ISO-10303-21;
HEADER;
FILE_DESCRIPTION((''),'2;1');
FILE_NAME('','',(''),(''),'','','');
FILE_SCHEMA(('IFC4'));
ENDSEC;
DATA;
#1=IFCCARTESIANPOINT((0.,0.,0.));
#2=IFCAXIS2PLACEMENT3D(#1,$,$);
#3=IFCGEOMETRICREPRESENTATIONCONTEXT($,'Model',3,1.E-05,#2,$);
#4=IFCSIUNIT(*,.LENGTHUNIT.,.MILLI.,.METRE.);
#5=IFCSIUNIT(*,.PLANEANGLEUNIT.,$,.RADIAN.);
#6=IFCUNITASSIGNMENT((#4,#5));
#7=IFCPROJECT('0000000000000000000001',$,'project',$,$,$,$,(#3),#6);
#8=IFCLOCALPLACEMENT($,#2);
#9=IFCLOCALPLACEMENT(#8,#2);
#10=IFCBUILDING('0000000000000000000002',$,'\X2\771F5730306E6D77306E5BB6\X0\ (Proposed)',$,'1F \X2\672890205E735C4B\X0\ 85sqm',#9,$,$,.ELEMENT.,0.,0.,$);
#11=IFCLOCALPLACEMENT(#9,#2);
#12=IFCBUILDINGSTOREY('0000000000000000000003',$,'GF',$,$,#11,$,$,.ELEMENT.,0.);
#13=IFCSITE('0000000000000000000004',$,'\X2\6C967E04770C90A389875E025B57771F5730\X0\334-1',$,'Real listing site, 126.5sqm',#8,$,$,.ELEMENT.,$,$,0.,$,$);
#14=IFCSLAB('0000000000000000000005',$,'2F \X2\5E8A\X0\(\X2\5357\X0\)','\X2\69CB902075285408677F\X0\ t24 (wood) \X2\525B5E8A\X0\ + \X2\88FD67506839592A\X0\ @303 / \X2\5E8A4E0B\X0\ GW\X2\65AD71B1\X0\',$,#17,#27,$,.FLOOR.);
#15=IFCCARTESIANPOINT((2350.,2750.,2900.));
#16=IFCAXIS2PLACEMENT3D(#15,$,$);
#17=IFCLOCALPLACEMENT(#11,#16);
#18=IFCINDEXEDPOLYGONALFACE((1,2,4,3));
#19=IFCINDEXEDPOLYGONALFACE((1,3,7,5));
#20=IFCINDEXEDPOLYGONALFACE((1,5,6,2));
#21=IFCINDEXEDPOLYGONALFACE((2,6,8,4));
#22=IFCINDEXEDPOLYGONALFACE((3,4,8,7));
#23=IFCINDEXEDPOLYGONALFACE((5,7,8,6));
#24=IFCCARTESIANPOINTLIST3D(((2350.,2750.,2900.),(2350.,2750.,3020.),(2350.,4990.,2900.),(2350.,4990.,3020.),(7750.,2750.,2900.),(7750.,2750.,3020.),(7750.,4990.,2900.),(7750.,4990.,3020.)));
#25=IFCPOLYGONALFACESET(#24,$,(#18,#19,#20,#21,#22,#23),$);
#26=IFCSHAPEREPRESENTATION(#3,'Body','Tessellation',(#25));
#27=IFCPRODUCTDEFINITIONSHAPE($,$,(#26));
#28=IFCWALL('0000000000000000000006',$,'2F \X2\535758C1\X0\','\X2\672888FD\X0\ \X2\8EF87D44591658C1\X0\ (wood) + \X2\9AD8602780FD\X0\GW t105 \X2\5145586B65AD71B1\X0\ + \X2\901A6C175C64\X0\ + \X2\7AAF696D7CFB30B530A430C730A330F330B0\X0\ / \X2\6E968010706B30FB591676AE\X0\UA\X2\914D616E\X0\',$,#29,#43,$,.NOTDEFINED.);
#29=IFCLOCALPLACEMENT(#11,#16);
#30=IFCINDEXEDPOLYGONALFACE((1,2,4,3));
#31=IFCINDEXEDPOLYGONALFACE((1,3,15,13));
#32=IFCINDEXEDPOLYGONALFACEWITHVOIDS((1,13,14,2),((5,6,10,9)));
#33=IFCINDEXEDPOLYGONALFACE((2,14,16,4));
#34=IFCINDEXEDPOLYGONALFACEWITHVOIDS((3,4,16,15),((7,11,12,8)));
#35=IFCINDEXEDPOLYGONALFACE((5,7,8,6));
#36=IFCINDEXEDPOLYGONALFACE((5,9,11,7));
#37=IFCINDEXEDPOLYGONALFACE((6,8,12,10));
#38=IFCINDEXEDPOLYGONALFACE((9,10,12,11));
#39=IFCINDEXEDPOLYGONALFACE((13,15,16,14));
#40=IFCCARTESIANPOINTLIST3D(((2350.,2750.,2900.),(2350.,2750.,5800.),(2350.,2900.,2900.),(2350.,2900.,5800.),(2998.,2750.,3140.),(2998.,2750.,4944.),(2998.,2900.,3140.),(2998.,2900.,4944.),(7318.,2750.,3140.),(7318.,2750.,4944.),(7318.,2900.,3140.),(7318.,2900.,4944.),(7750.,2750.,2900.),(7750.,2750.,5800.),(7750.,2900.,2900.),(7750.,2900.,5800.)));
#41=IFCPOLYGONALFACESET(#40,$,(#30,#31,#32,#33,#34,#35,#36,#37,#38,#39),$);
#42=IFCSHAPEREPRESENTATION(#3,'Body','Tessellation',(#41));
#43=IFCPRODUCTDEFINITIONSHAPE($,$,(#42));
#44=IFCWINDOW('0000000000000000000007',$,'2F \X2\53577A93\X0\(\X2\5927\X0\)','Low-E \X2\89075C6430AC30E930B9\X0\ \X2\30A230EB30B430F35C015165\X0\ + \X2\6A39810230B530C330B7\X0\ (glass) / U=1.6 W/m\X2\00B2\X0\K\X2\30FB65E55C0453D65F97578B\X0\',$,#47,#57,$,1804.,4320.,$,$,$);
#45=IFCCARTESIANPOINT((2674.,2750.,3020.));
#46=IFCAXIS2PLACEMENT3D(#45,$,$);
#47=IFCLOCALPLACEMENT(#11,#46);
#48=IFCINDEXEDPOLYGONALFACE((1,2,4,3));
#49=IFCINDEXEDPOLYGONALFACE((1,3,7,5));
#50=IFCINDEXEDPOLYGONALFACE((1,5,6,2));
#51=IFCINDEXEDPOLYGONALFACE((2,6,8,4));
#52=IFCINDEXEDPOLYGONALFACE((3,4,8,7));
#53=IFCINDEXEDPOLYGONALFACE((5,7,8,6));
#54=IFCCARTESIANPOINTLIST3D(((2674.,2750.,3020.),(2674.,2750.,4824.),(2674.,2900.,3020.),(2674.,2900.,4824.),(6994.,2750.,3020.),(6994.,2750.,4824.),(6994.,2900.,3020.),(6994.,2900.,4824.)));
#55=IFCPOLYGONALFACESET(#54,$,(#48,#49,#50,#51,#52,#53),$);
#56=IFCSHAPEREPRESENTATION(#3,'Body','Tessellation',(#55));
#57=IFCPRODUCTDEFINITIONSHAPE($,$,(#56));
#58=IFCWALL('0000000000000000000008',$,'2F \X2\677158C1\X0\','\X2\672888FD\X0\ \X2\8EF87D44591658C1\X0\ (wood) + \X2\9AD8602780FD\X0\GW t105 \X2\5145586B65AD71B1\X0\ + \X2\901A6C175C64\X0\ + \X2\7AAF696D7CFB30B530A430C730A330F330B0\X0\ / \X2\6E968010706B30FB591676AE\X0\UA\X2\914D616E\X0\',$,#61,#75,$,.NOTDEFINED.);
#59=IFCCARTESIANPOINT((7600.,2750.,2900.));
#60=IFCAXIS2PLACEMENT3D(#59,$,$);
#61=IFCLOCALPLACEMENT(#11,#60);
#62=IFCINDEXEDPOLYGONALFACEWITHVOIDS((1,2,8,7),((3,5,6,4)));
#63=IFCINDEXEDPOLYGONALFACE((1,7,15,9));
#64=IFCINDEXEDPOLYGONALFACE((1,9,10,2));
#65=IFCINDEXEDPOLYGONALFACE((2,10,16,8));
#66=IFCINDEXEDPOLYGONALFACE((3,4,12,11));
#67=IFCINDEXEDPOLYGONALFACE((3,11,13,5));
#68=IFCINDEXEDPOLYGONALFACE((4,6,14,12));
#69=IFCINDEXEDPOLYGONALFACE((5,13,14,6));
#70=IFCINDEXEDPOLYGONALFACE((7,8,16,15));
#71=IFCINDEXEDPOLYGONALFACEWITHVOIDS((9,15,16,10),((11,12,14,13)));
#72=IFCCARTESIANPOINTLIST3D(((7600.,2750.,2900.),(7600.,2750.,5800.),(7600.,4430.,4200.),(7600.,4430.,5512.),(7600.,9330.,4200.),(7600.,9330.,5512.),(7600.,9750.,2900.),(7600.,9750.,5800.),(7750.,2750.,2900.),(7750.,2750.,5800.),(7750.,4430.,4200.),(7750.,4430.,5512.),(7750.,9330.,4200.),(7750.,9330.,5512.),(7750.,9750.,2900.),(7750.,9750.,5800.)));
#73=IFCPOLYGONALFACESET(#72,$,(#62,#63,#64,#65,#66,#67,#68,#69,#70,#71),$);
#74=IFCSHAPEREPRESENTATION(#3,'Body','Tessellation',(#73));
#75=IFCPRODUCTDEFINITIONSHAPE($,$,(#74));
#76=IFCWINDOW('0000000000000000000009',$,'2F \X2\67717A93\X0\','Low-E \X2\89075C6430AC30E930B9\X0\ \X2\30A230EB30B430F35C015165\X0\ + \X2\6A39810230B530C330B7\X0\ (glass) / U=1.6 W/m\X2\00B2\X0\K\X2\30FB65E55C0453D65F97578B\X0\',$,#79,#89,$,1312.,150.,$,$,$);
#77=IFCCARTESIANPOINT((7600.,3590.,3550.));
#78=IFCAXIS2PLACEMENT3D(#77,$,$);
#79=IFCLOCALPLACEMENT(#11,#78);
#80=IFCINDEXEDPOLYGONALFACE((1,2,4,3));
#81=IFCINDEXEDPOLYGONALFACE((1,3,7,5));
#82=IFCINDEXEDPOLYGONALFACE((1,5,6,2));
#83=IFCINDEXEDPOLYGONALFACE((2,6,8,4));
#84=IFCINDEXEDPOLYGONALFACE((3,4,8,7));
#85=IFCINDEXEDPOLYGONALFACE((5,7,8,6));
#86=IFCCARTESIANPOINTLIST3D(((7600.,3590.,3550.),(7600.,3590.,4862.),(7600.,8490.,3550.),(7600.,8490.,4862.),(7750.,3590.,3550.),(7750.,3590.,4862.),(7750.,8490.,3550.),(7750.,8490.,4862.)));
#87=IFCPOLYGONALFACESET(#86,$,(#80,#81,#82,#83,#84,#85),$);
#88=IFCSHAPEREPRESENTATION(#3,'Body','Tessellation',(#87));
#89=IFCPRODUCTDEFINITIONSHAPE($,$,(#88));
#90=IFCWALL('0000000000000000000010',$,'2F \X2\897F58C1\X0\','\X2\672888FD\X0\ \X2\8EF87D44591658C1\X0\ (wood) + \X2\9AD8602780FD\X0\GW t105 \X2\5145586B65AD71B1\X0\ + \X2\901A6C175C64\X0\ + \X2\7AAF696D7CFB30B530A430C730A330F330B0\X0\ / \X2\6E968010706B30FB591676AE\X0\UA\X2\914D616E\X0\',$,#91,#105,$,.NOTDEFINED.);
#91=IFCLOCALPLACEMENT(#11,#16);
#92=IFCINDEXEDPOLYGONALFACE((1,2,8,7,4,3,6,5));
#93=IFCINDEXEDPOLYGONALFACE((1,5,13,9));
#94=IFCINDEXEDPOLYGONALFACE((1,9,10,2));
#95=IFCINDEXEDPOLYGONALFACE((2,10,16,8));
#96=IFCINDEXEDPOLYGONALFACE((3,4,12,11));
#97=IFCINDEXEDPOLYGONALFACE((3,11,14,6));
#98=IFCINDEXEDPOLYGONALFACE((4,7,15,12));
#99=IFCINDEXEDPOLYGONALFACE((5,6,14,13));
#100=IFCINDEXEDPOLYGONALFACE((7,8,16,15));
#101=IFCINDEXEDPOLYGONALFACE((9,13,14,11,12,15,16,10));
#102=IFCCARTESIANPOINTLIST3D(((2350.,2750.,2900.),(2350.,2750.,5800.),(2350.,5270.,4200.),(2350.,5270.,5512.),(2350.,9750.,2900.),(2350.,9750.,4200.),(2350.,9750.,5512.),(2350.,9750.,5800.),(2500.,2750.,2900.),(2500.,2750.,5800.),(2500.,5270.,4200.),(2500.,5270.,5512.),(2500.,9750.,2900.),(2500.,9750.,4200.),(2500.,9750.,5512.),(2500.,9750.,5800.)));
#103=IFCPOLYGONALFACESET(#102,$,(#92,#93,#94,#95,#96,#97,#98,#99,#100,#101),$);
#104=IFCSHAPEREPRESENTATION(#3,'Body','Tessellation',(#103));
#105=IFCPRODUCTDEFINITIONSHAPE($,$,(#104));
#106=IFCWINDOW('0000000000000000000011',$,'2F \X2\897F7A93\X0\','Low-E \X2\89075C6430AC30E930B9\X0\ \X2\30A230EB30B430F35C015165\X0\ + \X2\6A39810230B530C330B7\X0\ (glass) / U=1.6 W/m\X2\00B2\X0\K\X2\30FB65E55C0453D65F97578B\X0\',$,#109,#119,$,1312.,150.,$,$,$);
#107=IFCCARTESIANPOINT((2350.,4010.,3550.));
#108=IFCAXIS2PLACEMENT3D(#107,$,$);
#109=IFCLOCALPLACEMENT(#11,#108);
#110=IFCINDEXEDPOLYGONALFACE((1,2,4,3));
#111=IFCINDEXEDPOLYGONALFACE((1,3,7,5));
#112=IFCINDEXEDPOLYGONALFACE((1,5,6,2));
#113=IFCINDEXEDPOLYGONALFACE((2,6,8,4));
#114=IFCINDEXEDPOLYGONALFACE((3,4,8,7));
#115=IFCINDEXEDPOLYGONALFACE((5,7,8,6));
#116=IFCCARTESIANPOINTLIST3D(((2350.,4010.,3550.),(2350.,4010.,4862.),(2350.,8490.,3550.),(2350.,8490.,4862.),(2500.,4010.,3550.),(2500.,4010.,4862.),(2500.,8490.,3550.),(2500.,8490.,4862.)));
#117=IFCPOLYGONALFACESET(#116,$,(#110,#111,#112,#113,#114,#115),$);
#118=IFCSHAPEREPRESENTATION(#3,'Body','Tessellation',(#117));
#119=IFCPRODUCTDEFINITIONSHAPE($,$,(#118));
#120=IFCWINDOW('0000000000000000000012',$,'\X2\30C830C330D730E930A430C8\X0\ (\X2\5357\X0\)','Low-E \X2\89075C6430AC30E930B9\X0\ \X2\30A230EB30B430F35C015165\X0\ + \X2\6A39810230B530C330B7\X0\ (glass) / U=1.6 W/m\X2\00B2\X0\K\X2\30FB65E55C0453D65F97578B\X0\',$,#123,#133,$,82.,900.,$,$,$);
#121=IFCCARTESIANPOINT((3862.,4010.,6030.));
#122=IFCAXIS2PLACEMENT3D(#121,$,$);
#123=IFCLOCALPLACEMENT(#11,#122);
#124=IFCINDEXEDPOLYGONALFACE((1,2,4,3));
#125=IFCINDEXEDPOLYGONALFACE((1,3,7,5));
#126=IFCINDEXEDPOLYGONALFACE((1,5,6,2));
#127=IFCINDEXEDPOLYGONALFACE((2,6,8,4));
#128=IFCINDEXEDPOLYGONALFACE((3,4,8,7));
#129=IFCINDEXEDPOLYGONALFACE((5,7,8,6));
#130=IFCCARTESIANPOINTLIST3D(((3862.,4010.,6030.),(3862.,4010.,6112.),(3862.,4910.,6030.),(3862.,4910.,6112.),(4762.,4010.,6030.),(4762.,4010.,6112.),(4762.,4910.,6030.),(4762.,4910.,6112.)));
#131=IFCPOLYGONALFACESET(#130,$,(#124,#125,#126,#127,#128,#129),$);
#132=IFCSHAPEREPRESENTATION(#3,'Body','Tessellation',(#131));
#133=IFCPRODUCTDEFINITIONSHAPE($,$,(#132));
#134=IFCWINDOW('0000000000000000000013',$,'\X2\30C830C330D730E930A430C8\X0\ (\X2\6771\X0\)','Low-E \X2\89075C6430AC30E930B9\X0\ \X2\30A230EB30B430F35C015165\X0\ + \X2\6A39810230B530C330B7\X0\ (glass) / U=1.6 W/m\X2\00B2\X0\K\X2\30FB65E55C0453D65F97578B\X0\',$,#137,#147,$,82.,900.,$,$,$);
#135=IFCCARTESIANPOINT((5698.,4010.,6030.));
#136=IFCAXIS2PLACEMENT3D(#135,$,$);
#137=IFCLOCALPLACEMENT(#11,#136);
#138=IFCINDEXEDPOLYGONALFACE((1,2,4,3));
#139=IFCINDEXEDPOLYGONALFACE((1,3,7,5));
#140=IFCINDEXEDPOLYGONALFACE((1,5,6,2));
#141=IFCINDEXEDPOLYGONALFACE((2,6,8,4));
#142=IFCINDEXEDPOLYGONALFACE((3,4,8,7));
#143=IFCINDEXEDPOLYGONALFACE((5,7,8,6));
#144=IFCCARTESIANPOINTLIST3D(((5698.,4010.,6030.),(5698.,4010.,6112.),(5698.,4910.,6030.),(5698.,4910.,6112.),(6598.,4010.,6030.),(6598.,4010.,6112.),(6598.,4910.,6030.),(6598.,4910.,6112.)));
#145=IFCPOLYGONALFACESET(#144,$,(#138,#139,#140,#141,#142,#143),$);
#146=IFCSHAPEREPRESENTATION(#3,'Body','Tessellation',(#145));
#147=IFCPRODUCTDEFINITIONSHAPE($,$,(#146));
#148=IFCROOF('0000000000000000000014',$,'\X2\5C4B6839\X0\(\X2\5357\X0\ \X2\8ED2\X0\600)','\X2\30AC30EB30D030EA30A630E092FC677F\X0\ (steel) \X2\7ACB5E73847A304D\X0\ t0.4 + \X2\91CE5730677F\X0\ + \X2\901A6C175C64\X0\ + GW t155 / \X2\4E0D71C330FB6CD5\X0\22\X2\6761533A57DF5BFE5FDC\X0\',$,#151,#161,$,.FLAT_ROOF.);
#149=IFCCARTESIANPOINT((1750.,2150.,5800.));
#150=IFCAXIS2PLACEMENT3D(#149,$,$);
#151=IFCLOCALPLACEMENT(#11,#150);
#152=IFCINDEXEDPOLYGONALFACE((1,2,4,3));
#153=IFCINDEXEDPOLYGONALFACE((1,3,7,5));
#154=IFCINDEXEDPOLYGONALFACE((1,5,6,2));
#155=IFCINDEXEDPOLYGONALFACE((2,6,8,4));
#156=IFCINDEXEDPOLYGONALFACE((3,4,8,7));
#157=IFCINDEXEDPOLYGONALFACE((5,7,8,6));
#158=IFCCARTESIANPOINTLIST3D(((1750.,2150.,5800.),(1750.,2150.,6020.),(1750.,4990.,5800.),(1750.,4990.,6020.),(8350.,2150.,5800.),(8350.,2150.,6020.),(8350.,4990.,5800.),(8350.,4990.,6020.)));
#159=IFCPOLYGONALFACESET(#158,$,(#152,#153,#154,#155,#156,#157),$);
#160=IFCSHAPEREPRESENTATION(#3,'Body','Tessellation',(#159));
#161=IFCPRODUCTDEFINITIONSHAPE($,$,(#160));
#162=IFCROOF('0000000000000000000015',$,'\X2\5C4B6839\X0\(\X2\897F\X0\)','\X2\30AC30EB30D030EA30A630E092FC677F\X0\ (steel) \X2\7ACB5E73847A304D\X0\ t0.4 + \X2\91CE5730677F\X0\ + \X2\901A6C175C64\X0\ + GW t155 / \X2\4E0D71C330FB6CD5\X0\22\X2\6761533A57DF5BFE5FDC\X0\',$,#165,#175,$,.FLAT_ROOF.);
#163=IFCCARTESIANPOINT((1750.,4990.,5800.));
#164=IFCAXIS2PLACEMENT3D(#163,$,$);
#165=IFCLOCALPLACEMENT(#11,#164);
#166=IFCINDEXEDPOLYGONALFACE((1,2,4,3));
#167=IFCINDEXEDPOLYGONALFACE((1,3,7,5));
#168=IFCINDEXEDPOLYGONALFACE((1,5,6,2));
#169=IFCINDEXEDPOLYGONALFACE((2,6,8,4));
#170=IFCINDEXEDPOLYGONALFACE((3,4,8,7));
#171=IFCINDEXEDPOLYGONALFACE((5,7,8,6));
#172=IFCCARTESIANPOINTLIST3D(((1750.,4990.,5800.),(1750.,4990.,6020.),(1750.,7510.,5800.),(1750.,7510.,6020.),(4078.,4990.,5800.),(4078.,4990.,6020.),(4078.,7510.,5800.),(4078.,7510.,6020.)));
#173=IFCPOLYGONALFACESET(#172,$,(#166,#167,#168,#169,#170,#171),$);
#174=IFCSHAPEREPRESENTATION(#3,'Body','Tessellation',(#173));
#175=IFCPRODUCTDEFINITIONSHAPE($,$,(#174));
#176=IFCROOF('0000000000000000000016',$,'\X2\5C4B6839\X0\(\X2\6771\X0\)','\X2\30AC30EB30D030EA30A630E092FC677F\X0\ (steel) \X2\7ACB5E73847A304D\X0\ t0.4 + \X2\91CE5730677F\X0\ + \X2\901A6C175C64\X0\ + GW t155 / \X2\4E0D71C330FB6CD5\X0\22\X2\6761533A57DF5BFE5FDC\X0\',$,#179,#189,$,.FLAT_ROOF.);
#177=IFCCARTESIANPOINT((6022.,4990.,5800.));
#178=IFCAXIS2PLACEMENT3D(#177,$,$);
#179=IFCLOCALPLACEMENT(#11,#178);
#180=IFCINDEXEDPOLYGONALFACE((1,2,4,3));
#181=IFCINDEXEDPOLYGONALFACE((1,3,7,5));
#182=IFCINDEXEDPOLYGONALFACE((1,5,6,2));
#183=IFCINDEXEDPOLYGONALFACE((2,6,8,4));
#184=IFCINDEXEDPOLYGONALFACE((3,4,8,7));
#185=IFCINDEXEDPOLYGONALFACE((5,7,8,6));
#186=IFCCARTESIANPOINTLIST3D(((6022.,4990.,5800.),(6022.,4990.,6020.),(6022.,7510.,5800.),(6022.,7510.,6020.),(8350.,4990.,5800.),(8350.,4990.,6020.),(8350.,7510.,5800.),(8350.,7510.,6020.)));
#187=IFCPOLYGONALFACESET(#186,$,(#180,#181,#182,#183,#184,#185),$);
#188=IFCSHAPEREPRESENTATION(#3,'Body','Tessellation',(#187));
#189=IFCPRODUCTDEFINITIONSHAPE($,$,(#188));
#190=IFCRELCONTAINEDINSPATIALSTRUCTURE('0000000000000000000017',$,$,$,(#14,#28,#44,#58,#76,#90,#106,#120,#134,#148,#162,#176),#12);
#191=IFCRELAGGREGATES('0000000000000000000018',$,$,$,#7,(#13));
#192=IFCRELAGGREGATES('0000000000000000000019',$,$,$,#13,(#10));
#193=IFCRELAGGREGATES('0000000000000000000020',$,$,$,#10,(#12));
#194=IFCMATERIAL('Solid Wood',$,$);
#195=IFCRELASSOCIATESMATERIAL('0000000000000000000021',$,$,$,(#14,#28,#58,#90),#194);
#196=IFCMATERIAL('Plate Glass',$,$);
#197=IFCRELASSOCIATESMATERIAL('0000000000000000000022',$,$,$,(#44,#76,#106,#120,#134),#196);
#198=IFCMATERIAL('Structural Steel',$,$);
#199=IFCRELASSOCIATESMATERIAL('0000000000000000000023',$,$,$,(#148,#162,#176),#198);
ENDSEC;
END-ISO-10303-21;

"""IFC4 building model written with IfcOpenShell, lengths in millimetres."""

from ifc_helpers import new_model, si_unit, frame, frame_2d, origin, place, context, project, spatial, rectangle, extrude, material, element, fill, save


model = new_model("IFC4")

# Units and contexts
model_context = context("Model", 3, precision=1e-05, world=origin())
ifc_project = project(units=[si_unit("LENGTHUNIT", "METRE", prefix="MILLI"), si_unit("PLANEANGLEUNIT", "RADIAN")], contexts=[model_context])

# Site, building, storey
site_placement = place(None, origin())
site = spatial("IfcSite", under=ifc_project, at=site_placement, Name="沖縄県那覇市字真地334-1", ObjectType="Real listing site, 126.5sqm", CompositionType="ELEMENT", RefElevation=0.0)
building_placement = place(site_placement, origin())
building = spatial("IfcBuilding", under=site, at=building_placement, Name="真地の海の家 (Proposed)", ObjectType="1F 木造平屋 85sqm", CompositionType="ELEMENT", ElevationOfRefHeight=0.0, ElevationOfTerrain=0.0)
storey_placement = place(building_placement, origin())
storey = spatial("IfcBuildingStorey", under=building, at=storey_placement, Name="GF", CompositionType="ELEMENT", Elevation=0.0)

# Slab
ifc_material_1 = material(Name="Solid Wood")
slab_placement = place(storey_placement, frame((2350.0, 2750.0, 2900.0)))
element("IfcSlab", 1, at=slab_placement, inside=storey, material=ifc_material_1, Name="2F 床(南)", Description="構造用合板 t24 (wood) 剛床 + 製材根太 @303 / 床下 GW断熱", PredefinedType="FLOOR", context=model_context, shape_type="SweptSolid", body=[
    extrude(rectangle(XDim=5400.0, YDim=2240.0, at=frame_2d((2700.0, 1120.0))), frame((2350.0, 2750.0, 2900.0)), (0.0, 0.0, 1.0), 120.0),
])

# Walls, openings, windows
wall_1_placement = place(storey_placement, frame((2350.0, 2750.0, 2900.0)))
wall_1 = element("IfcWall", 2, at=wall_1_placement, inside=storey, material=ifc_material_1, Name="2F 南壁", Description="木製 軸組外壁 (wood) + 高性能GW t105 充填断熱 + 通気層 + 窯業系サイディング / 準耐火・外皮UA配慮", PredefinedType="NOTDEFINED", context=model_context, shape_type="SweptSolid", body=[
    extrude(rectangle(XDim=5400.0, YDim=150.0, at=frame_2d((2700.0, 75.0))), frame((2350.0, 2750.0, 2900.0)), (0.0, 0.0, 1.0), 2900.0),
])
opening_1_placement = place(storey_placement, frame((2674.0, 2750.0, 3020.0)))
opening_1 = element("IfcOpeningElement", 3, at=opening_1_placement, cuts=wall_1, PredefinedType="NOTDEFINED", context=model_context, shape_type="SweptSolid", body=[
    extrude(rectangle(XDim=4320.0, YDim=150.0, at=frame_2d((2160.0, 75.0))), frame((2674.0, 2750.0, 3020.0)), (0.0, 0.0, 1.0), 1804.0),
])
ifc_material_2 = material(Name="Plate Glass")
window_1_placement = place(storey_placement, frame((2674.0, 2750.0, 3020.0)))
window_1 = element("IfcWindow", 4, at=window_1_placement, inside=storey, material=ifc_material_2, Name="2F 南窓(大)", Description="Low-E 複層ガラス アルゴン封入 + 樹脂サッシ (glass) / U=1.6 W/m²K・日射取得型", OverallHeight=1804.0, OverallWidth=4320.0, context=model_context, shape_type="SweptSolid", body=[
    extrude(rectangle(XDim=4320.0, YDim=150.0, at=frame_2d((2160.0, 75.0))), frame((2674.0, 2750.0, 3020.0)), (0.0, 0.0, 1.0), 1804.0),
])
fill(opening_1, window_1)
wall_2_placement = place(storey_placement, frame((7600.0, 2750.0, 2900.0)))
wall_2 = element("IfcWall", 5, at=wall_2_placement, inside=storey, material=ifc_material_1, Name="2F 東壁", Description="木製 軸組外壁 (wood) + 高性能GW t105 充填断熱 + 通気層 + 窯業系サイディング / 準耐火・外皮UA配慮", PredefinedType="NOTDEFINED", context=model_context, shape_type="SweptSolid", body=[
    extrude(rectangle(XDim=150.0, YDim=7000.0, at=frame_2d((75.0, 3500.0))), frame((7600.0, 2750.0, 2900.0)), (0.0, 0.0, 1.0), 2900.0),
])
opening_2_placement = place(storey_placement, frame((7600.0, 3590.0, 3550.0)))
opening_2 = element("IfcOpeningElement", 6, at=opening_2_placement, cuts=wall_2, PredefinedType="NOTDEFINED", context=model_context, shape_type="SweptSolid", body=[
    extrude(rectangle(XDim=150.0, YDim=4900.0, at=frame_2d((75.0, 2450.0))), frame((7600.0, 3590.0, 3550.0)), (0.0, 0.0, 1.0), 1312.0),
])
window_2_placement = place(storey_placement, frame((7600.0, 3590.0, 3550.0)))
window_2 = element("IfcWindow", 7, at=window_2_placement, inside=storey, material=ifc_material_2, Name="2F 東窓", Description="Low-E 複層ガラス アルゴン封入 + 樹脂サッシ (glass) / U=1.6 W/m²K・日射取得型", OverallHeight=1312.0, OverallWidth=150.0, context=model_context, shape_type="SweptSolid", body=[
    extrude(rectangle(XDim=150.0, YDim=4900.0, at=frame_2d((75.0, 2450.0))), frame((7600.0, 3590.0, 3550.0)), (0.0, 0.0, 1.0), 1312.0),
])
fill(opening_2, window_2)
wall_3_placement = place(storey_placement, frame((2350.0, 2750.0, 2900.0)))
wall_3 = element("IfcWall", 8, at=wall_3_placement, inside=storey, material=ifc_material_1, Name="2F 西壁", Description="木製 軸組外壁 (wood) + 高性能GW t105 充填断熱 + 通気層 + 窯業系サイディング / 準耐火・外皮UA配慮", PredefinedType="NOTDEFINED", context=model_context, shape_type="SweptSolid", body=[
    extrude(rectangle(XDim=150.0, YDim=7000.0, at=frame_2d((75.0, 3500.0))), frame((2350.0, 2750.0, 2900.0)), (0.0, 0.0, 1.0), 2900.0),
])
opening_3_placement = place(storey_placement, frame((2350.0, 4010.0, 3550.0)))
opening_3 = element("IfcOpeningElement", 9, at=opening_3_placement, cuts=wall_3, PredefinedType="NOTDEFINED", context=model_context, shape_type="SweptSolid", body=[
    extrude(rectangle(XDim=150.0, YDim=4480.0, at=frame_2d((75.0, 2240.0))), frame((2350.0, 4010.0, 3550.0)), (0.0, 0.0, 1.0), 1312.0),
])
window_3_placement = place(storey_placement, frame((2350.0, 4010.0, 3550.0)))
window_3 = element("IfcWindow", 10, at=window_3_placement, inside=storey, material=ifc_material_2, Name="2F 西窓", Description="Low-E 複層ガラス アルゴン封入 + 樹脂サッシ (glass) / U=1.6 W/m²K・日射取得型", OverallHeight=1312.0, OverallWidth=150.0, context=model_context, shape_type="SweptSolid", body=[
    extrude(rectangle(XDim=150.0, YDim=4480.0, at=frame_2d((75.0, 2240.0))), frame((2350.0, 4010.0, 3550.0)), (0.0, 0.0, 1.0), 1312.0),
])
fill(opening_3, window_3)

# Windows
window_4_placement = place(storey_placement, frame((3862.0, 4010.0, 6030.0)))
element("IfcWindow", 11, at=window_4_placement, inside=storey, material=ifc_material_2, Name="トップライト (南)", Description="Low-E 複層ガラス アルゴン封入 + 樹脂サッシ (glass) / U=1.6 W/m²K・日射取得型", OverallHeight=82.0, OverallWidth=900.0, context=model_context, shape_type="SweptSolid", body=[
    extrude(rectangle(XDim=900.0, YDim=900.0, at=frame_2d((450.0, 450.0))), frame((3862.0, 4010.0, 6030.0)), (0.0, 0.0, 1.0), 82.0),
])
window_5_placement = place(storey_placement, frame((5698.0, 4010.0, 6030.0)))
element("IfcWindow", 12, at=window_5_placement, inside=storey, material=ifc_material_2, Name="トップライト (東)", Description="Low-E 複層ガラス アルゴン封入 + 樹脂サッシ (glass) / U=1.6 W/m²K・日射取得型", OverallHeight=82.0, OverallWidth=900.0, context=model_context, shape_type="SweptSolid", body=[
    extrude(rectangle(XDim=900.0, YDim=900.0, at=frame_2d((450.0, 450.0))), frame((5698.0, 4010.0, 6030.0)), (0.0, 0.0, 1.0), 82.0),
])

# Roofs
ifc_material_3 = material(Name="Structural Steel")
roof_1_placement = place(storey_placement, frame((1750.0, 2150.0, 5800.0)))
element("IfcRoof", 13, at=roof_1_placement, inside=storey, material=ifc_material_3, Name="屋根(南 軒600)", Description="ガルバリウム鋼板 (steel) 立平葺き t0.4 + 野地板 + 通気層 + GW t155 / 不燃・法22条区域対応", PredefinedType="FLAT_ROOF", context=model_context, shape_type="SweptSolid", body=[
    extrude(rectangle(XDim=6600.0, YDim=2840.0, at=frame_2d((3300.0, 1420.0))), frame((1750.0, 2150.0, 5800.0)), (0.0, 0.0, 1.0), 220.0),
])
roof_2_placement = place(storey_placement, frame((1750.0, 4990.0, 5800.0)))
element("IfcRoof", 14, at=roof_2_placement, inside=storey, material=ifc_material_3, Name="屋根(西)", Description="ガルバリウム鋼板 (steel) 立平葺き t0.4 + 野地板 + 通気層 + GW t155 / 不燃・法22条区域対応", PredefinedType="FLAT_ROOF", context=model_context, shape_type="SweptSolid", body=[
    extrude(rectangle(XDim=2328.0, YDim=2520.0, at=frame_2d((1164.0, 1260.0))), frame((1750.0, 4990.0, 5800.0)), (0.0, 0.0, 1.0), 220.0),
])
roof_3_placement = place(storey_placement, frame((6022.0, 4990.0, 5800.0)))
element("IfcRoof", 15, at=roof_3_placement, inside=storey, material=ifc_material_3, Name="屋根(東)", Description="ガルバリウム鋼板 (steel) 立平葺き t0.4 + 野地板 + 通気層 + GW t155 / 不燃・法22条区域対応", PredefinedType="FLAT_ROOF", context=model_context, shape_type="SweptSolid", body=[
    extrude(rectangle(XDim=2328.0, YDim=2520.0, at=frame_2d((1164.0, 1260.0))), frame((6022.0, 4990.0, 5800.0)), (0.0, 0.0, 1.0), 220.0),
])

save(model, "model.ifc")
